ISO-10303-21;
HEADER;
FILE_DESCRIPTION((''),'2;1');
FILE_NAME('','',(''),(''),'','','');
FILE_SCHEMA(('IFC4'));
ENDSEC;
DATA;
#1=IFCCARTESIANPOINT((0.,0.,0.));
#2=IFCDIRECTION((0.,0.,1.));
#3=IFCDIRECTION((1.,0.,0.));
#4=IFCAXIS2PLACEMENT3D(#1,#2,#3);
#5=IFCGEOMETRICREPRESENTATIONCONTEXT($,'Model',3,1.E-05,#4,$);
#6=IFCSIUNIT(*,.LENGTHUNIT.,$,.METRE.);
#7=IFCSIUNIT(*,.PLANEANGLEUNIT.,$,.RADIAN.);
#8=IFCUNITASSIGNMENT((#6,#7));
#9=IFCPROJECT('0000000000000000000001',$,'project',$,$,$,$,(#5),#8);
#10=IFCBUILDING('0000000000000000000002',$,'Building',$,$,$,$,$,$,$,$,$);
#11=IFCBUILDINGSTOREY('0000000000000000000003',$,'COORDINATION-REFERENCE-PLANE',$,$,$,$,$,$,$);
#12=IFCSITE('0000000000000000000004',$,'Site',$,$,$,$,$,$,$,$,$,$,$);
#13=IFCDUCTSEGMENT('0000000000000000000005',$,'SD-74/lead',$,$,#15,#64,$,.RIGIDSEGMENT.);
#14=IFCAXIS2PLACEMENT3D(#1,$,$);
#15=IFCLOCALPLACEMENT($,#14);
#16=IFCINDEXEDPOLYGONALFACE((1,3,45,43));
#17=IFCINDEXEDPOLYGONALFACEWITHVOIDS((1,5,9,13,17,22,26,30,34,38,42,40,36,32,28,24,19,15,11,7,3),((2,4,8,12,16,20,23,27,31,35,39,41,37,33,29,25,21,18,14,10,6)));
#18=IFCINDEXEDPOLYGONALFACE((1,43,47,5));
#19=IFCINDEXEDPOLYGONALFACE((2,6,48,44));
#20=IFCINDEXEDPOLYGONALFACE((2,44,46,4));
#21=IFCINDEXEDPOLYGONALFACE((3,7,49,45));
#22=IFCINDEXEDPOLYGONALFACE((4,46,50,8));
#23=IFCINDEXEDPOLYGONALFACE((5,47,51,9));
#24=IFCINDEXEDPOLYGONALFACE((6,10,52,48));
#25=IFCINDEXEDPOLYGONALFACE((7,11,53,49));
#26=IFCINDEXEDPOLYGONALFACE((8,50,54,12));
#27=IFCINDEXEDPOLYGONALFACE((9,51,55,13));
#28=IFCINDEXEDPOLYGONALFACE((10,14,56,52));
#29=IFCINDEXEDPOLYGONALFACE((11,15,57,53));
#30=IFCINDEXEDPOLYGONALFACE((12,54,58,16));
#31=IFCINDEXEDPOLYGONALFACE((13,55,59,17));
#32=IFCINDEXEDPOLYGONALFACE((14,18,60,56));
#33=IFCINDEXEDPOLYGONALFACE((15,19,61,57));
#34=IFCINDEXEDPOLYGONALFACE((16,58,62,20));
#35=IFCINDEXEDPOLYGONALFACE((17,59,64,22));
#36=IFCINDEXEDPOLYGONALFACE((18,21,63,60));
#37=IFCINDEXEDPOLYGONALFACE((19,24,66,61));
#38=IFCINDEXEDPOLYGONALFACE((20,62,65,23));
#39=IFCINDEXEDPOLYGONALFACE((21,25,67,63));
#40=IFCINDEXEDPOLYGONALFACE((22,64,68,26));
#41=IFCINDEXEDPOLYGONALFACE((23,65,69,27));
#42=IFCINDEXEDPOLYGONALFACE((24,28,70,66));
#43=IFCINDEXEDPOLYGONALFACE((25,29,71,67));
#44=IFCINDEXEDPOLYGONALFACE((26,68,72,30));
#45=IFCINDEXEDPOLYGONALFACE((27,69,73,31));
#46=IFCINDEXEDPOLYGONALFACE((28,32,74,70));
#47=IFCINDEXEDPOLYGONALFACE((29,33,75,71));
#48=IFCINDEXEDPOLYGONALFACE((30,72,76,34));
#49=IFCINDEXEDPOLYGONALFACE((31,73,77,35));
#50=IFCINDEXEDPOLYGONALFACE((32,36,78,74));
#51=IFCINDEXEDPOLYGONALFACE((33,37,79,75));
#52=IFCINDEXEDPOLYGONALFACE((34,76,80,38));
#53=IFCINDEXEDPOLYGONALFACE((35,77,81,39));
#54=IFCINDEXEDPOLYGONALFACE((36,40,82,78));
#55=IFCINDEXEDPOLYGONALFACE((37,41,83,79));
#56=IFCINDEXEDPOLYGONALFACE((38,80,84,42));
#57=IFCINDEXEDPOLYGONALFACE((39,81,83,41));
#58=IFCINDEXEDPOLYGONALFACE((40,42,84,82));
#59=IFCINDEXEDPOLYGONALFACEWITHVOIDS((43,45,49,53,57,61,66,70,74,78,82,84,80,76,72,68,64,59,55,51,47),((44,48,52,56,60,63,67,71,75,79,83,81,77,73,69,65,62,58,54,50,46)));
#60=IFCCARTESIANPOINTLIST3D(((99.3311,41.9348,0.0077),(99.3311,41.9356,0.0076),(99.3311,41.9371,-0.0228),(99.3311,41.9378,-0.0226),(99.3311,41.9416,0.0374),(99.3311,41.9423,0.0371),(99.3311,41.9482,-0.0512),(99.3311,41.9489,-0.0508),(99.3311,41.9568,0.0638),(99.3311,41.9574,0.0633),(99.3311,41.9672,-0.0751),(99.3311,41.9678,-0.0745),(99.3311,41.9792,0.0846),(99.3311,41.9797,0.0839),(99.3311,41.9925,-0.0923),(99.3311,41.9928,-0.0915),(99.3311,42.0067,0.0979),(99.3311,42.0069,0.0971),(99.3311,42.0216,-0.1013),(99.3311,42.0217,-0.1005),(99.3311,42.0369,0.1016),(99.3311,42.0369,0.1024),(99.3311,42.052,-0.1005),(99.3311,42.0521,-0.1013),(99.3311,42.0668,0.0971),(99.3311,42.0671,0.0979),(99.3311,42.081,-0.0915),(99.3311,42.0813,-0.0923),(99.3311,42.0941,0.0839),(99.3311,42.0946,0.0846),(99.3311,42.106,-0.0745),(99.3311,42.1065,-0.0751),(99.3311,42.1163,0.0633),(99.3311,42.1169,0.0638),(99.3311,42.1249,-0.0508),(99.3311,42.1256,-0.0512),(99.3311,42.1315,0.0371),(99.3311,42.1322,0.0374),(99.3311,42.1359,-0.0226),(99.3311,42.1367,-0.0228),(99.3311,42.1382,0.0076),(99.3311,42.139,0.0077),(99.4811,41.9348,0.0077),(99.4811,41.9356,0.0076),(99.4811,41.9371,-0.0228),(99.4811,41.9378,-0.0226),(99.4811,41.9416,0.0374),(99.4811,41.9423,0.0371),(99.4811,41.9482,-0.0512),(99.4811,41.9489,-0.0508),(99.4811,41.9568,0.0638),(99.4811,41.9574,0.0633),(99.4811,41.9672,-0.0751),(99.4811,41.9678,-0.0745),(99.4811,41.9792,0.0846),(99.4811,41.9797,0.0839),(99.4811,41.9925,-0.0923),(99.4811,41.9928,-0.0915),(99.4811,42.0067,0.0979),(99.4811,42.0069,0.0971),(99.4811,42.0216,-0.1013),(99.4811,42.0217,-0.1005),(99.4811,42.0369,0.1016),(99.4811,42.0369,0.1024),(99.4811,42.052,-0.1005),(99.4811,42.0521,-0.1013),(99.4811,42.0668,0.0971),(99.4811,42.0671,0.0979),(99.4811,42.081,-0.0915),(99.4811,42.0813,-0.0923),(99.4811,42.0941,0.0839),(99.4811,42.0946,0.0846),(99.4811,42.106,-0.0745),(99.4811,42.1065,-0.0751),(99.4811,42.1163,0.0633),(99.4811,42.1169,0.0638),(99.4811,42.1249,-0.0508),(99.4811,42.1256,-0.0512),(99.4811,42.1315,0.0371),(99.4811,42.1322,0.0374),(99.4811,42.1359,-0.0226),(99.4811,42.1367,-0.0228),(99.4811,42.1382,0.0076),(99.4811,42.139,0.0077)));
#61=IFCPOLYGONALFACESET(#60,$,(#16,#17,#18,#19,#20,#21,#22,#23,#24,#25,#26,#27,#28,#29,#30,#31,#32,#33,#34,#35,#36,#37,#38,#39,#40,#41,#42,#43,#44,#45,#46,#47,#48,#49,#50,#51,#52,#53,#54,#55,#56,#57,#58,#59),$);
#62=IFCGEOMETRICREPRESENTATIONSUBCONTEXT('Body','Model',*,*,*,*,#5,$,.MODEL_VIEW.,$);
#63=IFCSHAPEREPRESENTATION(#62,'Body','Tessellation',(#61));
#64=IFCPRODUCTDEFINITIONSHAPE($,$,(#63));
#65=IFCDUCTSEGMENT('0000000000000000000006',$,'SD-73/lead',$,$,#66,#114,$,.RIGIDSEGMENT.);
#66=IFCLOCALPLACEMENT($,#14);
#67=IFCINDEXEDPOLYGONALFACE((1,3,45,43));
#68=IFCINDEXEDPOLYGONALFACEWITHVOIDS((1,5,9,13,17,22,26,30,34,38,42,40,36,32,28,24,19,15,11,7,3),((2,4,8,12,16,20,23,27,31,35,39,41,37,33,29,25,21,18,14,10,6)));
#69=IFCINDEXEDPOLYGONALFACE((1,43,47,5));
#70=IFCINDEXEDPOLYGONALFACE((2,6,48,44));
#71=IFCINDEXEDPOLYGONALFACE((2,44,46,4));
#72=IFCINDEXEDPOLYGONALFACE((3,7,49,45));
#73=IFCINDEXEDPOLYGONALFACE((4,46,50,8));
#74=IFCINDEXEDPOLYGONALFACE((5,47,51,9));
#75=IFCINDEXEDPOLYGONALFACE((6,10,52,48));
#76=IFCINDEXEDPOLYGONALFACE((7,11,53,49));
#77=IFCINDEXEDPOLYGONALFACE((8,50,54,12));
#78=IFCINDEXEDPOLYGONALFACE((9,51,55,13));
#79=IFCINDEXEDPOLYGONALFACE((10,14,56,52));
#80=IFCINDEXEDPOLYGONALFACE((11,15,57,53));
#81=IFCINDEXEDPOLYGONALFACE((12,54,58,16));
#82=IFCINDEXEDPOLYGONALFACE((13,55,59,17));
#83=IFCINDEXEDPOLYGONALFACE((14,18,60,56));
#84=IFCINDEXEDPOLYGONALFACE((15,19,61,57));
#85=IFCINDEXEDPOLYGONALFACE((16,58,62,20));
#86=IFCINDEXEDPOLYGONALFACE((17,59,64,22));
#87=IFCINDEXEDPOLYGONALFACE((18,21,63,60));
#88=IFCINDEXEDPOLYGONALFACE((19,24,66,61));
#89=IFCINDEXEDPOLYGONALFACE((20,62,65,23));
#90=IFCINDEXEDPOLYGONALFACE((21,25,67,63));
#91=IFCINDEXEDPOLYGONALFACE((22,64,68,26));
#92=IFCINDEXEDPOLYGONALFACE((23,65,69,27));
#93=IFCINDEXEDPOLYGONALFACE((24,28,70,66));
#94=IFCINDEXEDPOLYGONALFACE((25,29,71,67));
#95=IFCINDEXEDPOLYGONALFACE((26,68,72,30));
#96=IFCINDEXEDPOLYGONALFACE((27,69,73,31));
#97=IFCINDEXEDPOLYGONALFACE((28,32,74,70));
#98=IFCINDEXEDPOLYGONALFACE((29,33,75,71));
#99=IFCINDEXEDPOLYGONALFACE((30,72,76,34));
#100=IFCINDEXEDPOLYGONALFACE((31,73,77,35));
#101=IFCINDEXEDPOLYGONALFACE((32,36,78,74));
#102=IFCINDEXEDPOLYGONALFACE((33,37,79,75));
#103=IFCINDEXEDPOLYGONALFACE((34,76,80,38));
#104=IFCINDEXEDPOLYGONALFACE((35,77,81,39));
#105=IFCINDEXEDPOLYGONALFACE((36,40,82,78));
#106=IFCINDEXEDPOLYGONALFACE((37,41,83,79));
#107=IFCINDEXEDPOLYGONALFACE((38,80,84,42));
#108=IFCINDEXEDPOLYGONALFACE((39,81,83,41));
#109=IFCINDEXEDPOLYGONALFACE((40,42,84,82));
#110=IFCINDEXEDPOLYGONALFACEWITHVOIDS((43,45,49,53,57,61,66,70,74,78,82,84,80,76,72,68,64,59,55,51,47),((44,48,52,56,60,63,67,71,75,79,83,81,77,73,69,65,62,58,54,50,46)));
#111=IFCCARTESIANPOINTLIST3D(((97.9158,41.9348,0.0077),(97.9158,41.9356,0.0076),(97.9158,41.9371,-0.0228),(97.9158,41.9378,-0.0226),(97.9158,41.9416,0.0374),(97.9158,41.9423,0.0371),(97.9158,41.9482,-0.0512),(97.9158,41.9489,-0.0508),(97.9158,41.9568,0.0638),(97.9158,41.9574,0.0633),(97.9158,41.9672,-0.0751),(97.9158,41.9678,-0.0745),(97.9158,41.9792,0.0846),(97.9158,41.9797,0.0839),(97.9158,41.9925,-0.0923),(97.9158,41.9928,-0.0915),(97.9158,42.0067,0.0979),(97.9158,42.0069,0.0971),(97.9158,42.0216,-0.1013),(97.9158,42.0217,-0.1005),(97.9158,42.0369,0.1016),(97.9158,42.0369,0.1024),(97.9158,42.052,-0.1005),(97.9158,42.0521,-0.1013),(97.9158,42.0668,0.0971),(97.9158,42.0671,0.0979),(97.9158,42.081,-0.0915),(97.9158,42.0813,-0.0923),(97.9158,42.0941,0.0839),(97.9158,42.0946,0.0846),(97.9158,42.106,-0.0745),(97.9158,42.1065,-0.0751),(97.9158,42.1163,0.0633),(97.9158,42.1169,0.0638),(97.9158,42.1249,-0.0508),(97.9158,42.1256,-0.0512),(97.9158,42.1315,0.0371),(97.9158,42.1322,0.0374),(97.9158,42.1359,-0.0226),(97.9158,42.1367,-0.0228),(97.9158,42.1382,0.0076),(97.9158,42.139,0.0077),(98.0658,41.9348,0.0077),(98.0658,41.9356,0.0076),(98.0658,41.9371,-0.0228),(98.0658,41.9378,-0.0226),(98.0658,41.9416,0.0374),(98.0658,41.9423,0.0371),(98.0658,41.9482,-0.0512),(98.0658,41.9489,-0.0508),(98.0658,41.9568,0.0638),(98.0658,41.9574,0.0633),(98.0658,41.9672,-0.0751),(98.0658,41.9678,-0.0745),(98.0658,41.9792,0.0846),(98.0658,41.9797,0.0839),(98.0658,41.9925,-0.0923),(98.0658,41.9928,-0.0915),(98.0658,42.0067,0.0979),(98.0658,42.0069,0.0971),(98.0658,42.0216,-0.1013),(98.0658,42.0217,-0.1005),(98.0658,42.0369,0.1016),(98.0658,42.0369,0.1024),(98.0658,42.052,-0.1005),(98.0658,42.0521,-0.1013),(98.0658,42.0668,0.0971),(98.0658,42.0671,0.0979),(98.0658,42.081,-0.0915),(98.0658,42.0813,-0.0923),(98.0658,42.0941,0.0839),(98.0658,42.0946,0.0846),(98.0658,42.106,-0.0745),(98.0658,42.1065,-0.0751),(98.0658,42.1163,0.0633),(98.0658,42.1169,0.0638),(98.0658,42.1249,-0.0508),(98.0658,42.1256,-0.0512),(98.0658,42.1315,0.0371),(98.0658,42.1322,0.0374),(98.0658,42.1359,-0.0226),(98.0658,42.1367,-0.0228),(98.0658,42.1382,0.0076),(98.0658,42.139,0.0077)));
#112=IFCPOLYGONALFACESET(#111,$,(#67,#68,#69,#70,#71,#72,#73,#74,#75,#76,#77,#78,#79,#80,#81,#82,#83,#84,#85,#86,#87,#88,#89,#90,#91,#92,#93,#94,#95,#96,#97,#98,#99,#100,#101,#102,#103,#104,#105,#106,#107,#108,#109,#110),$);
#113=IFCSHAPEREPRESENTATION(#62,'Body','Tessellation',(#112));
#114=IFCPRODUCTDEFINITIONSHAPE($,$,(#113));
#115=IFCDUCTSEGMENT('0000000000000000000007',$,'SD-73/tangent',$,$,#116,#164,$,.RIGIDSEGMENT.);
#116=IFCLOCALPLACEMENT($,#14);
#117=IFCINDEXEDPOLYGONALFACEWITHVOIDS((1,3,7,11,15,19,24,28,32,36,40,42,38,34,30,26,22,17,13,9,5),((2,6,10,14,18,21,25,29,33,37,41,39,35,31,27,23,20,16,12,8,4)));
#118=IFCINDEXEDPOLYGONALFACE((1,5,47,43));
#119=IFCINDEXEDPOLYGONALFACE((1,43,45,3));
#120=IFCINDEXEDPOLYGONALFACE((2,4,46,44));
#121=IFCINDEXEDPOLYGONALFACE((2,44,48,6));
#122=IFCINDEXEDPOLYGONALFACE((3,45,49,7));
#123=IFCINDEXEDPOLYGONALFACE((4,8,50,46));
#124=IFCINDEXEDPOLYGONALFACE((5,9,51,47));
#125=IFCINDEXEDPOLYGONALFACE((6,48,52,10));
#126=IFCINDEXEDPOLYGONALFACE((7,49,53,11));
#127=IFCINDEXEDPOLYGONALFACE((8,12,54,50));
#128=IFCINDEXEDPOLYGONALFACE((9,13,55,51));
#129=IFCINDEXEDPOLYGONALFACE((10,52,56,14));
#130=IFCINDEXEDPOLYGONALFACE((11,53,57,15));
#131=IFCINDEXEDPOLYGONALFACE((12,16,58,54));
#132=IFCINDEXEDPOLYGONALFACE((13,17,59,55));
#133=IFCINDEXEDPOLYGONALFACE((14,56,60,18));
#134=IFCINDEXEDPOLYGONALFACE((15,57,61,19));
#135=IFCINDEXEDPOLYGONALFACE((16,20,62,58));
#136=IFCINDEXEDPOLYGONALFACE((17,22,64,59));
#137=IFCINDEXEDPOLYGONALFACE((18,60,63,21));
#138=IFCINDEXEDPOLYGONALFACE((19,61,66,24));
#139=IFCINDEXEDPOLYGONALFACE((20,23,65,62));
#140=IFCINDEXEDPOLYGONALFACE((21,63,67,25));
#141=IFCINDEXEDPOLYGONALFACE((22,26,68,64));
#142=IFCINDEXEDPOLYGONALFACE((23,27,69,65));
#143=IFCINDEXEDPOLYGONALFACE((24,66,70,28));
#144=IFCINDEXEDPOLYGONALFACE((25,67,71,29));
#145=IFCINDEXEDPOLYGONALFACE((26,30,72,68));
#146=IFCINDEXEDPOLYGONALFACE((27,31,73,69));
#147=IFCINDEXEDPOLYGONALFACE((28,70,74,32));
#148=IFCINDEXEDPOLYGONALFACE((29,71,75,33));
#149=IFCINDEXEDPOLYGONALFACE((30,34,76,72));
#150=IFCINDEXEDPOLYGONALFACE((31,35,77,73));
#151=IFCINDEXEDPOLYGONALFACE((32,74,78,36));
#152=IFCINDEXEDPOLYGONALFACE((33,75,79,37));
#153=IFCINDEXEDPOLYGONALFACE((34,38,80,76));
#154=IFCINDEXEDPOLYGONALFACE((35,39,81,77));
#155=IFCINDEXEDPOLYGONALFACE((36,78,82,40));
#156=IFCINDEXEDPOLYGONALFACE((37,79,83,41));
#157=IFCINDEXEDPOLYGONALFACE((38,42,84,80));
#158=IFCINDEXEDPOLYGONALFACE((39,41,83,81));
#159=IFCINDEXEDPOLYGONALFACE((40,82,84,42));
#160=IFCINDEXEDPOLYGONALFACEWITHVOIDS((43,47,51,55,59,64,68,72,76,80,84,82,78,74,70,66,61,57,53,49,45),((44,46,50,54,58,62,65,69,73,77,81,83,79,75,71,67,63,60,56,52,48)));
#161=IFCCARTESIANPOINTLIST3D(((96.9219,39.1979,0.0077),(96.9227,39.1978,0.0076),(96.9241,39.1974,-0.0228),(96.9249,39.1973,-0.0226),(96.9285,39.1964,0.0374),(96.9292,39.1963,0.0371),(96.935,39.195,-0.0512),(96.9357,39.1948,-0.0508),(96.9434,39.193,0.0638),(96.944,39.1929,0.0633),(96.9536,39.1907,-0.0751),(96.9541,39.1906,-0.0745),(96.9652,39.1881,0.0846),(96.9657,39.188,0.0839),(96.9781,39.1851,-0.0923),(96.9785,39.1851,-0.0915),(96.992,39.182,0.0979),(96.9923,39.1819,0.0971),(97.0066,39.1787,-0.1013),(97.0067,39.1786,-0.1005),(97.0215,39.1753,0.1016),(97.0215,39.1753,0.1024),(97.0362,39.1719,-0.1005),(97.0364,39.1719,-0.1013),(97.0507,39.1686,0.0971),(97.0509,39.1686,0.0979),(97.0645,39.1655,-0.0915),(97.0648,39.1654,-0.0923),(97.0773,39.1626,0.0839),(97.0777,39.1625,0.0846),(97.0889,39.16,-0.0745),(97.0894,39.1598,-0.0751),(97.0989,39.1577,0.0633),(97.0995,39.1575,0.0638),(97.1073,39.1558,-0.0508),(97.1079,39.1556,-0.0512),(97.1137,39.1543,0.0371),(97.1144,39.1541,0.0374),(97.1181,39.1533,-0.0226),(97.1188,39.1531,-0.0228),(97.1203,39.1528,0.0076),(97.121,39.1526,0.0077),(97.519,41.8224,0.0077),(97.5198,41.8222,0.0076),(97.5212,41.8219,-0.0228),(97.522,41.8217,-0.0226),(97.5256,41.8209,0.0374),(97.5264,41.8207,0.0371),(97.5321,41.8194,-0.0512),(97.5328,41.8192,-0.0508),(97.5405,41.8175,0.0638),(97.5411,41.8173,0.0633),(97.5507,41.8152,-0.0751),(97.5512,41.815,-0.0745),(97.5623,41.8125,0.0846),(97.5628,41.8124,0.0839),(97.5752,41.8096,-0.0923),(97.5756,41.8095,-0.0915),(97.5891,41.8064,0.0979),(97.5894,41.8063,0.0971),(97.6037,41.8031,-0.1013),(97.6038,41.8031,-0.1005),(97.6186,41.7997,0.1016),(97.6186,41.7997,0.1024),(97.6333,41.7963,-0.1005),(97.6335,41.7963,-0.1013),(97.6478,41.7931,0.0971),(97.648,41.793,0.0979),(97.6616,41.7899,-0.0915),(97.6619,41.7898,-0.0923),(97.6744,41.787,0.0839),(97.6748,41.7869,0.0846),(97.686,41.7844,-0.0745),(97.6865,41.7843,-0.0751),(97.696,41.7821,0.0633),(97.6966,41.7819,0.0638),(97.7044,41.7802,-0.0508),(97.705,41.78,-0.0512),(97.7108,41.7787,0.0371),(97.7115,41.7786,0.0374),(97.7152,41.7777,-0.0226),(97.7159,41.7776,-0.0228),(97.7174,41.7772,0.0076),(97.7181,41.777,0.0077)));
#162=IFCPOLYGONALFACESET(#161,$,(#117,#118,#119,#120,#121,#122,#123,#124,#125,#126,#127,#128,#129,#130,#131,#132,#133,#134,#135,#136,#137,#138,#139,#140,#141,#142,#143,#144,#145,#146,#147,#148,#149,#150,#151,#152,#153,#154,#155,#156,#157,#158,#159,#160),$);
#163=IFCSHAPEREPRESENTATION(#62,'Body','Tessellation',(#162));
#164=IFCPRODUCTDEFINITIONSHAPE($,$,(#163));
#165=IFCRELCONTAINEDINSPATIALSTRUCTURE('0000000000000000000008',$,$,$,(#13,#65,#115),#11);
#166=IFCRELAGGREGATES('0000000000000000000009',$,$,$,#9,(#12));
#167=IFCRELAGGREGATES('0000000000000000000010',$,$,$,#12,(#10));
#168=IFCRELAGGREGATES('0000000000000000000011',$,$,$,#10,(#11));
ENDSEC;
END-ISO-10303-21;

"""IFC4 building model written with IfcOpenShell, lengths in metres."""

from ifc_helpers import new_model, si_unit, frame, origin_with_axes, place, context, subcontext, project, spatial, hollow_circle, extrude, element, save


model = new_model("IFC4")

# Units and contexts
model_context_1 = context("Model", 3, precision=1e-05, world=origin_with_axes())
body_context_1 = subcontext(model_context_1, "Body", "Model", "MODEL_VIEW")
ifc_project = project(units=[si_unit("LENGTHUNIT", "METRE"), si_unit("PLANEANGLEUNIT", "RADIAN")], contexts=[model_context_1])

# Site, building, storey
site = spatial("IfcSite", under=ifc_project, Name="Site")
building = spatial("IfcBuilding", under=site, Name="Building")
storey = spatial("IfcBuildingStorey", under=building, Name="COORDINATION-REFERENCE-PLANE")

# Duct segments
for number, where, z_axis, x_axis, name in (
    (1, (99.3311, 42.0369, 0.0), (1.0, 0.0, 0.0), (0.0, 0.0, 1.0), "SD-74/lead"),
    (2, (98.0658, 42.0369, 0.0), (-1.0, 0.0, 0.0), (0.0, 0.0, 1.0), "SD-73/lead"),
):
    element("IfcDuctSegment", number, at=place(None, frame(where, z_axis=z_axis, x_axis=x_axis)), inside=storey, Name=name, PredefinedType="RIGIDSEGMENT", context=body_context_1, shape_type="SweptSolid", body=[
        extrude(hollow_circle(Radius=0.1024, WallThickness=0.0008), origin_with_axes(), (0.0, 0.0, 1.0), 0.15),
    ])

# Duct segment
duct_segment_1_placement = place(None, frame((97.6186, 41.7997, 0.0), z_axis=(-0.221849, -0.975081, 0.0), x_axis=(0.0, 0.0, 1.0)))
element("IfcDuctSegment", 3, at=duct_segment_1_placement, inside=storey, Name="SD-73/tangent", PredefinedType="RIGIDSEGMENT", context=body_context_1, shape_type="SweptSolid", body=[
    extrude(hollow_circle(Radius=0.1024, WallThickness=0.0008), origin_with_axes(), (0.0, 0.0, 1.0), 2.6915),
])

save(model, "model.ifc")
